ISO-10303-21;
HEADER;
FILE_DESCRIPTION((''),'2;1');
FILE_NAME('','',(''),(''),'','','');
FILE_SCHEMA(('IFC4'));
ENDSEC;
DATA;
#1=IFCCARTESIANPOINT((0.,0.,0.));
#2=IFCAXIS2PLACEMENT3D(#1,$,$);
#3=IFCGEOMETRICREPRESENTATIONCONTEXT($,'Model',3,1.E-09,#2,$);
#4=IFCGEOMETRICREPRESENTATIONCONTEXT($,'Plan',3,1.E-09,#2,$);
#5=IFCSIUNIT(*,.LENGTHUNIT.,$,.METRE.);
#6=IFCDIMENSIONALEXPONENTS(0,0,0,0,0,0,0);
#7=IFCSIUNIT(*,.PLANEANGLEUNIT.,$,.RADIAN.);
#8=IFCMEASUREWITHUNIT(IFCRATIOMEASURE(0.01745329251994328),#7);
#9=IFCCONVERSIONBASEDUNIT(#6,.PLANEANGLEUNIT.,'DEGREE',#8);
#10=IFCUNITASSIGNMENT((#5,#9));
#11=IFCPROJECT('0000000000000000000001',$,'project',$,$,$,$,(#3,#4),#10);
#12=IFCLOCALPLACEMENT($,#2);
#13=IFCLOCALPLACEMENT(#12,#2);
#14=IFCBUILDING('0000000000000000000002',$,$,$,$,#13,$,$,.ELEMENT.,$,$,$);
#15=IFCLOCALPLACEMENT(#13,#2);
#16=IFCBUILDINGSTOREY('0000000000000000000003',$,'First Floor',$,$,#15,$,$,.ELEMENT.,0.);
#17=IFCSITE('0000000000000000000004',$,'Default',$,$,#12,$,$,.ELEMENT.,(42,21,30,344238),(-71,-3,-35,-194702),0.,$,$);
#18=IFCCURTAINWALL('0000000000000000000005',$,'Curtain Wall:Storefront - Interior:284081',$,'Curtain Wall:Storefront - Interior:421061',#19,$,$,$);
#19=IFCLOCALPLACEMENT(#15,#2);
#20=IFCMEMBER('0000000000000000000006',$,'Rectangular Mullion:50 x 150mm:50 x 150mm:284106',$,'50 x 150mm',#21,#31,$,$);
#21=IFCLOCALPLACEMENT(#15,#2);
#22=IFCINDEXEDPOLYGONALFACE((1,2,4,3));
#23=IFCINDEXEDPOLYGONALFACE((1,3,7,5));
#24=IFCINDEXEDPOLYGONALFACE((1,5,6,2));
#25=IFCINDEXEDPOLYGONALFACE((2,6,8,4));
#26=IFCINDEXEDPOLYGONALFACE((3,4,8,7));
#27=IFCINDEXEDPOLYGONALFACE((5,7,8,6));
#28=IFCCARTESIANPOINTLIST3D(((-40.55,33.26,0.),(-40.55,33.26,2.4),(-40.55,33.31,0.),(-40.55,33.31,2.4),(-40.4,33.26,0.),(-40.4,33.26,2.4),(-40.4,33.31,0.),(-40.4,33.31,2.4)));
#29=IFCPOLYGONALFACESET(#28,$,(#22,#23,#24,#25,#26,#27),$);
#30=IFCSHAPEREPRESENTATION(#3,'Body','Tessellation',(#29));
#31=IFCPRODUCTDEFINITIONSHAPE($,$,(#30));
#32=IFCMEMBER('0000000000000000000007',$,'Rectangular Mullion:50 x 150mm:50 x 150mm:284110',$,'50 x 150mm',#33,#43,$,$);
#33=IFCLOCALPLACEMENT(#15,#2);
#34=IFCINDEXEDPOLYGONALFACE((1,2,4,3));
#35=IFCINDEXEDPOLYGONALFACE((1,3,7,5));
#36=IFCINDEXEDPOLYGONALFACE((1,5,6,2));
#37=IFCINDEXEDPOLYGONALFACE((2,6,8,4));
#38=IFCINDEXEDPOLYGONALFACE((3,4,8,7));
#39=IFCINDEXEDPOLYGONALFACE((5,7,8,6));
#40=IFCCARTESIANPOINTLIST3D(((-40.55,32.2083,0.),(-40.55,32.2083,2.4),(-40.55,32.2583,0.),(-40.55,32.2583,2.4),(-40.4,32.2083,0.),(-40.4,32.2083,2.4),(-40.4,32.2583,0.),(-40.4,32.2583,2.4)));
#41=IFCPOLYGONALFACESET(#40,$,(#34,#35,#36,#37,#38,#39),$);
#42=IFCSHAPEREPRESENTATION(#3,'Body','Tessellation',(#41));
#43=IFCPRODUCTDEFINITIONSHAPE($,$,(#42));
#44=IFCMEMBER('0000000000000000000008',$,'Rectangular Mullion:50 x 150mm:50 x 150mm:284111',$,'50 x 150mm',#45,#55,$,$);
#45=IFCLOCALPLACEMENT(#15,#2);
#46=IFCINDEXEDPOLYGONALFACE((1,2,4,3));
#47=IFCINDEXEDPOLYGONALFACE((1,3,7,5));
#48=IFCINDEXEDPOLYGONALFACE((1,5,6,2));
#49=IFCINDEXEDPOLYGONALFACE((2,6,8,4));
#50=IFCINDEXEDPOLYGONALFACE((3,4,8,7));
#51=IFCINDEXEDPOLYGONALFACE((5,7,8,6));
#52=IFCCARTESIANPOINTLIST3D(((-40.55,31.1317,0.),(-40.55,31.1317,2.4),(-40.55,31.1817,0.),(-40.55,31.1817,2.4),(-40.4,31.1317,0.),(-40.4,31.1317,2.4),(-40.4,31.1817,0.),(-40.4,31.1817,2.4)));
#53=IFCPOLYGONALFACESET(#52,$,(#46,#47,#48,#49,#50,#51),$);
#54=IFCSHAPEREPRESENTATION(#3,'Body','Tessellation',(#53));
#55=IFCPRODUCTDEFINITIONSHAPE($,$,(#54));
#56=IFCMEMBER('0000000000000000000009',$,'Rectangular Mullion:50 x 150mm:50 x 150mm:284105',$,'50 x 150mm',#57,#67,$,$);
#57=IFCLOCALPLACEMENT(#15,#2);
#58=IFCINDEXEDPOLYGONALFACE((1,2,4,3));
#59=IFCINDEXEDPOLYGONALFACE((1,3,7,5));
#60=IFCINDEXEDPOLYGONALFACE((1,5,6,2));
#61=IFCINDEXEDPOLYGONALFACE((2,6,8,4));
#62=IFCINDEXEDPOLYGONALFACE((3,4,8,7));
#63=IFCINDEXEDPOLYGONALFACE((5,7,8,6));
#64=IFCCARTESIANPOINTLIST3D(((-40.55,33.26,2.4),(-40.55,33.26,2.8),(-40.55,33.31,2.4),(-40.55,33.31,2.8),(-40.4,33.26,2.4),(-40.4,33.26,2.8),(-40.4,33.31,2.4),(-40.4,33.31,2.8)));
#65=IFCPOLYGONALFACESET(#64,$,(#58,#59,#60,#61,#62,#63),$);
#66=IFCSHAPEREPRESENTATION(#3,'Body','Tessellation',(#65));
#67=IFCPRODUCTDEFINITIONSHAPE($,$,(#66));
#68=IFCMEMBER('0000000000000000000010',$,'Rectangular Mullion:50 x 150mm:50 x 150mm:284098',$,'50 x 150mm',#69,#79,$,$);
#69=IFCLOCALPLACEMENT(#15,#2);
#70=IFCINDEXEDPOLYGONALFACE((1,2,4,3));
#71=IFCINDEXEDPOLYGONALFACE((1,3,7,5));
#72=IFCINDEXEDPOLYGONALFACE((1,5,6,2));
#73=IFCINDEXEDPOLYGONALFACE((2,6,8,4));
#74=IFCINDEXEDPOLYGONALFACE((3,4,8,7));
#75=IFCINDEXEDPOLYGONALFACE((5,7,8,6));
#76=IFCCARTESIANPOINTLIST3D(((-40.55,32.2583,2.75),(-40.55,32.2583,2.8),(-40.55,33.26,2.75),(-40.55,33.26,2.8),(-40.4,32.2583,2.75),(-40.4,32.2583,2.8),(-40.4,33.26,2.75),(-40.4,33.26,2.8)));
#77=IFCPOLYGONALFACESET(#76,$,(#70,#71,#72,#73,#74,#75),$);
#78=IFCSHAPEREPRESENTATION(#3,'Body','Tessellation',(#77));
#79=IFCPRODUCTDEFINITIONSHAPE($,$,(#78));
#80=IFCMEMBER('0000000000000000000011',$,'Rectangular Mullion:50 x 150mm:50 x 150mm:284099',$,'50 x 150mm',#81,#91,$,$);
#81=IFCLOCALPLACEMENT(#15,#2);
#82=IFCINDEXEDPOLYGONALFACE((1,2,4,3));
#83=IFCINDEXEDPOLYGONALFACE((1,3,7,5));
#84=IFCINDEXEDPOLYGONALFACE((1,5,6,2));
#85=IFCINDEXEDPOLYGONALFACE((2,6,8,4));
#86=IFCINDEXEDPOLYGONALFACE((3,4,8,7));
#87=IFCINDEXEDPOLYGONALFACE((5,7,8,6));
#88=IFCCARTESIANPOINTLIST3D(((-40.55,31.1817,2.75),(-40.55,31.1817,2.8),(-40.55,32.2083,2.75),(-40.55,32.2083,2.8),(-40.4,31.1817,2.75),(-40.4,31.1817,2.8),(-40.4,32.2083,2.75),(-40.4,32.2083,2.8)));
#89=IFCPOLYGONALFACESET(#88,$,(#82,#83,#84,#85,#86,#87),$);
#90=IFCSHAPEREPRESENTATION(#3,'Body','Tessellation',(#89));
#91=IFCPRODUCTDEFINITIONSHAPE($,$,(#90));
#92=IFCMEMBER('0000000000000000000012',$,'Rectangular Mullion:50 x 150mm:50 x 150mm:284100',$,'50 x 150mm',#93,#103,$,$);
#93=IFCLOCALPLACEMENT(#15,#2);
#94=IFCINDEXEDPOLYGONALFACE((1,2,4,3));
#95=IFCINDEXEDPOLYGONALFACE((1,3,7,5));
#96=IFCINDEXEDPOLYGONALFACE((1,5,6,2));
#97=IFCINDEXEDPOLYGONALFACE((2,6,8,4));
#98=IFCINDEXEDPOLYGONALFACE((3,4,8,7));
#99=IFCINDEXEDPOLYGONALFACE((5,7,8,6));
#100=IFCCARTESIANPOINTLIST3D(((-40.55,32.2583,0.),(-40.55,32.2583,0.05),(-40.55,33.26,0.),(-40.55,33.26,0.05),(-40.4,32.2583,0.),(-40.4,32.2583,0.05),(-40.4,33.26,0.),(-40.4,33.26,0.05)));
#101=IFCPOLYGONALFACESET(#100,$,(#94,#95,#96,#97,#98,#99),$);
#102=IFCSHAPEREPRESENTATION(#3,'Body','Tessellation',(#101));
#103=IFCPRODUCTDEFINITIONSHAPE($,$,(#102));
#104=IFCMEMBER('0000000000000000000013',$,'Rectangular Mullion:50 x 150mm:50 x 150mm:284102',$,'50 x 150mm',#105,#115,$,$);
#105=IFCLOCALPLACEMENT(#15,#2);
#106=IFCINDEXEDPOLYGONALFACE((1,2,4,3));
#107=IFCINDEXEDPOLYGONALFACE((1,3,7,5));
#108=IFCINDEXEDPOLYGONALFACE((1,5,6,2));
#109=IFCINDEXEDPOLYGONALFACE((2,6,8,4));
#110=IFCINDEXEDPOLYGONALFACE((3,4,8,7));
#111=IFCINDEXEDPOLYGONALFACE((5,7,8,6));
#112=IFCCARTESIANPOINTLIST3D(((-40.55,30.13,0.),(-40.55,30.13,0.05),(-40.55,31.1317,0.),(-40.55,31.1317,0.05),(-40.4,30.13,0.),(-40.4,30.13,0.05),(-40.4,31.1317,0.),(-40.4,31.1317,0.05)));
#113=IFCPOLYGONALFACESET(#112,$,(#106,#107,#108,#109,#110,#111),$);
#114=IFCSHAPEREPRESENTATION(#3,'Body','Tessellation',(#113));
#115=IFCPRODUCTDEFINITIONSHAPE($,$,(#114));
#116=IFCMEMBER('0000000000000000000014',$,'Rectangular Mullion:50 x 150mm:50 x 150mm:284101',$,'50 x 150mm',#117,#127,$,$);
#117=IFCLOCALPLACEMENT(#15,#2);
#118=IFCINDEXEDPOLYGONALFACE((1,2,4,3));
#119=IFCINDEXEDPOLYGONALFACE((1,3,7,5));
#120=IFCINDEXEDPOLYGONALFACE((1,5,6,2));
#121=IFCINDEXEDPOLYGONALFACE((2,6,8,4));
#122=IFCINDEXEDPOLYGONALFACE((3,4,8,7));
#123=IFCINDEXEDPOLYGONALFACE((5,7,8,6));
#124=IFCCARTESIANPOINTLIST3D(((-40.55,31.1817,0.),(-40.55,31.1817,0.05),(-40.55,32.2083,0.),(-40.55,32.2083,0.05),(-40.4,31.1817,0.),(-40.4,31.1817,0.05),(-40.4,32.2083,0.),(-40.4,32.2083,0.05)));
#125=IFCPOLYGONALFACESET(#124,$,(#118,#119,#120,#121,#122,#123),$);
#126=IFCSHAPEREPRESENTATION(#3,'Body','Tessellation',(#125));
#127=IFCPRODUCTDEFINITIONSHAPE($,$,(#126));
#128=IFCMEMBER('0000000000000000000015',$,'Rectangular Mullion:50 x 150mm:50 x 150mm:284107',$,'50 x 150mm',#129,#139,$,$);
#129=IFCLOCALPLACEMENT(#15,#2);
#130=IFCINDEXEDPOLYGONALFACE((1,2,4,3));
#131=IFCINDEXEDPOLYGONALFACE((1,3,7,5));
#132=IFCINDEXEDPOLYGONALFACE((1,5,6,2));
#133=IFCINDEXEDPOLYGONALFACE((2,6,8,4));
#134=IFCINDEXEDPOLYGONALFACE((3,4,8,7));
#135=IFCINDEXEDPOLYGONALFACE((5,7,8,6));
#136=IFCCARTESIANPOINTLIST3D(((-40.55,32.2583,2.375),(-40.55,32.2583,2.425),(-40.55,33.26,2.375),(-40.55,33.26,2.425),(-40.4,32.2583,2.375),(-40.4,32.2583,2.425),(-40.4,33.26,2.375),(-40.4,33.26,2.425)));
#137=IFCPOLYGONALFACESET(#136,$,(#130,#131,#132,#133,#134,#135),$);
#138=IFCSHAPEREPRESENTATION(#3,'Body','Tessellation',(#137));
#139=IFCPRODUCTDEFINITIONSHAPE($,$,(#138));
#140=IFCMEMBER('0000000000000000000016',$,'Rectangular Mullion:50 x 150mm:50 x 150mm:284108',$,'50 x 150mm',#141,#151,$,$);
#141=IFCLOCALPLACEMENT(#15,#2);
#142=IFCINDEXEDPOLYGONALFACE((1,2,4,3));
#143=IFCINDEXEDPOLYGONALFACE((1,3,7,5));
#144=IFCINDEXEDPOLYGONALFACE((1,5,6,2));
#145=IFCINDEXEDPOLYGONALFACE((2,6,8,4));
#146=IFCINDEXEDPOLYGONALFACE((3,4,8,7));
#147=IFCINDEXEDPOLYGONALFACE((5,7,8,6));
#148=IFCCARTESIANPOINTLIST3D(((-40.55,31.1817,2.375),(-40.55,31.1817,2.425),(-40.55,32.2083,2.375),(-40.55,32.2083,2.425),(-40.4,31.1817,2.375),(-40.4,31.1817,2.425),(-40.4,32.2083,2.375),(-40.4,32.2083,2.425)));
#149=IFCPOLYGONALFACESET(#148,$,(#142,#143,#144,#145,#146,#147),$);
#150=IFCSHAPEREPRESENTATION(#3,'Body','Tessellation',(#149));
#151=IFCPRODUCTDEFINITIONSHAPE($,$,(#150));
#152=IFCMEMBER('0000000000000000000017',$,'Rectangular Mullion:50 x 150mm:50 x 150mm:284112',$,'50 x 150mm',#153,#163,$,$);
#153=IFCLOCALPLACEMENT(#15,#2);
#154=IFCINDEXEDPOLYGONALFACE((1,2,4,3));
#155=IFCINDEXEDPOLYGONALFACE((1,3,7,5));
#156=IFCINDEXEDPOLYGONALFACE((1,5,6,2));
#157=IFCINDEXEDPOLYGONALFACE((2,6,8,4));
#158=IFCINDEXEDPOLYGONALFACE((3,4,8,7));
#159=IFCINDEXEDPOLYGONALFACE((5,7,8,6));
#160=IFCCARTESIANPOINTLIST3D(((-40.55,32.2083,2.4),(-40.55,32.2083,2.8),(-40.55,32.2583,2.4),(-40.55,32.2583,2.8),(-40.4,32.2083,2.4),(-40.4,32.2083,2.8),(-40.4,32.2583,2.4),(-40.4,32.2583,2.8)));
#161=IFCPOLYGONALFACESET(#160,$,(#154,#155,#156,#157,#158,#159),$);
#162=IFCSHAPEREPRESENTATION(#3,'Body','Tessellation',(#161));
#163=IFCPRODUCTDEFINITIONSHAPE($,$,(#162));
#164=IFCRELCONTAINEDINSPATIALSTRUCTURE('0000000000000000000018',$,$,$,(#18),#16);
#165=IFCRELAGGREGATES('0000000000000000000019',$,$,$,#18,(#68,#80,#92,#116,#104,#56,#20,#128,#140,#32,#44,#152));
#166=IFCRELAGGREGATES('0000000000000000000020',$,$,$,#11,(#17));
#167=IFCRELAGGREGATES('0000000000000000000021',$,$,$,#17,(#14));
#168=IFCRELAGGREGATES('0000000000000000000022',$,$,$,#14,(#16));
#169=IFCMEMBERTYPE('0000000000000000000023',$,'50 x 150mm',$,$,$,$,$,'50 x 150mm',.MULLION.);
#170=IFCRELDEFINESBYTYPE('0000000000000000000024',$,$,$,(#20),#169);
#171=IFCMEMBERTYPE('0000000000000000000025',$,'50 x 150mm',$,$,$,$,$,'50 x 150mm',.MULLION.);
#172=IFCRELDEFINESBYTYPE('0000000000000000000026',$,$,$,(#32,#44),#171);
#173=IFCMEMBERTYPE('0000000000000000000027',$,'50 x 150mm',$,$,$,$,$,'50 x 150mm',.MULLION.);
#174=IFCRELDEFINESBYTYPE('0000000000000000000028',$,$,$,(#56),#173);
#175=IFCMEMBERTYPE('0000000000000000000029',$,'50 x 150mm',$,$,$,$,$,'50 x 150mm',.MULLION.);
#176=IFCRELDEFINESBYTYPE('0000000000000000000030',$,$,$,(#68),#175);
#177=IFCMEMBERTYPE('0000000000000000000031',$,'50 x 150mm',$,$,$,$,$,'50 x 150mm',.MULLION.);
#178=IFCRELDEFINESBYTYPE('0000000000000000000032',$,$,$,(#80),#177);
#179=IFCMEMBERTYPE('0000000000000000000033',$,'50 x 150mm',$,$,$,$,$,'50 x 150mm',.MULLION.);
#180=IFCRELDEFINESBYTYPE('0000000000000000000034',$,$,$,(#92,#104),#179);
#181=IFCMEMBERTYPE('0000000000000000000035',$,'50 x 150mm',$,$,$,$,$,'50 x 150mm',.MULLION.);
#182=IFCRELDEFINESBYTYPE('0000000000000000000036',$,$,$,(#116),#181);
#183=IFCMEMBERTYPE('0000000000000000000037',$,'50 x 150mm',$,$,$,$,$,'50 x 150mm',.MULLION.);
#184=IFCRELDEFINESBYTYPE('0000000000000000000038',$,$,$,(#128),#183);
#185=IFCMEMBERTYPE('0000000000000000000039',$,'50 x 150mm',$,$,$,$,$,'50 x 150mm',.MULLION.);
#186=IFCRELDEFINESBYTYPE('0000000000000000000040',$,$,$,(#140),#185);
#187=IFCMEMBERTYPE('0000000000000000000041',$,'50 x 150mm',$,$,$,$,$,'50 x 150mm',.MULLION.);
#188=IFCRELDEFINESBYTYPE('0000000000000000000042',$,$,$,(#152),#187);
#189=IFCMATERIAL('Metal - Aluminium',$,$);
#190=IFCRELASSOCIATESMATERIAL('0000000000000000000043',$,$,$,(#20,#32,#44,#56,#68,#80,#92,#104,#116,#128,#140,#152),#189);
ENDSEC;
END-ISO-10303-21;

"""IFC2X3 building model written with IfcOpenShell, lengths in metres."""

from ifc_helpers import new_model, entity, si_unit, converted_unit, frame, origin, origin_2d_with_axis, place, context, project, spatial, rectangle, extrude, source, transform, mapped, material, type_object, type_shapes, element, aggregate, save


model = new_model("IFC2X3")

# Units and contexts
model_context = context("Model", 3, precision=1e-09, world=origin())
plan_context = context("Plan", 3, precision=1e-09, world=origin())
ifc_project = project(units=[si_unit("LENGTHUNIT", "METRE"), converted_unit("PLANEANGLEUNIT", "DEGREE", entity("IfcRatioMeasure", 0.01745329251994328), si_unit("PLANEANGLEUNIT", "RADIAN"), dimensions=[0, 0, 0, 0, 0, 0, 0])], contexts=[model_context, plan_context])

# Site, building, storey
site_placement = place(None, origin())
site = spatial("IfcSite", under=ifc_project, at=site_placement, Name="Default", CompositionType="ELEMENT", RefLatitude=(42, 21, 30, 344238), RefLongitude=(-71, -3, -35, -194702), RefElevation=0.0)
building_placement = place(site_placement, origin())
building = spatial("IfcBuilding", under=site, at=building_placement, CompositionType="ELEMENT")
storey_placement = place(building_placement, origin())
storey = spatial("IfcBuildingStorey", under=building, at=storey_placement, Name="First Floor", CompositionType="ELEMENT", Elevation=0.0)

# Curtain wall, members
curtain_wall_placement = place(storey_placement, origin())
curtain_wall = element("IfcCurtainWall", 1, at=curtain_wall_placement, inside=storey, Name="Curtain Wall:Storefront - Interior:284081", ObjectType="Curtain Wall:Storefront - Interior:421061")
ifc_material_1 = material(Name="Metal - Aluminium")
member_type_1 = type_object("IfcMemberType", Name="50 x 150mm", ElementType="50 x 150mm", PredefinedType="MULLION")
shared_shape_1 = source(origin(), model_context, "Body", "SweptSolid", [
    extrude(rectangle(XDim=0.05, YDim=0.15, at=origin_2d_with_axis()), frame((-0.025, 0.0, -2.4), z_axis=(0.0, 0.0, 1.0), x_axis=(-1.0, 0.0, 0.0)), (0.0, 0.0, 1.0), 2.4),
])
type_shapes(member_type_1, [shared_shape_1])
member_1_placement = place(storey_placement, frame((-40.475, 33.31, 2.4), z_axis=(0.0, 0.0, 1.0), x_axis=(0.0, 1.0, 0.0)))
member_1 = element("IfcMember", 2, at=member_1_placement, type_object=member_type_1, material=ifc_material_1, Name="Rectangular Mullion:50 x 150mm:50 x 150mm:284106", ObjectType="50 x 150mm", context=model_context, shape_type="MappedRepresentation", body=[
    mapped(shared_shape_1, transform((0.0, 0.0, 0.0), scale=1.0)),
])
member_type_2 = type_object("IfcMemberType", Name="50 x 150mm", ElementType="50 x 150mm", PredefinedType="MULLION")
shared_shape_2 = source(origin(), model_context, "Body", "SweptSolid", [
    extrude(rectangle(XDim=0.05, YDim=0.15, at=origin_2d_with_axis()), frame((0.0, 0.0, -2.4), z_axis=(0.0, 0.0, 1.0), x_axis=(-1.0, 0.0, 0.0)), (0.0, 0.0, 1.0), 2.4),
])
type_shapes(member_type_2, [shared_shape_2])
member_2_placement = place(storey_placement, frame((-40.475, 32.2333, 0.0), z_axis=(0.0, 0.0, -1.0), x_axis=(0.0, -1.0, 0.0)))
member_2 = element("IfcMember", 3, at=member_2_placement, type_object=member_type_2, material=ifc_material_1, Name="Rectangular Mullion:50 x 150mm:50 x 150mm:284110", ObjectType="50 x 150mm", context=model_context, shape_type="MappedRepresentation", body=[
    mapped(shared_shape_2, transform((0.0, 0.0, 0.0), scale=1.0)),
])
member_3_placement = place(storey_placement, frame((-40.475, 31.1567, 0.0), z_axis=(0.0, 0.0, -1.0), x_axis=(0.0, -1.0, 0.0)))
member_3 = element("IfcMember", 4, at=member_3_placement, type_object=member_type_2, material=ifc_material_1, Name="Rectangular Mullion:50 x 150mm:50 x 150mm:284111", ObjectType="50 x 150mm", context=model_context, shape_type="MappedRepresentation", body=[
    mapped(shared_shape_2, transform((0.0, 0.0, 0.0), scale=1.0)),
])
member_type_3 = type_object("IfcMemberType", Name="50 x 150mm", ElementType="50 x 150mm", PredefinedType="MULLION")
shared_shape_3 = source(origin(), model_context, "Body", "SweptSolid", [
    extrude(rectangle(XDim=0.05, YDim=0.15, at=origin_2d_with_axis()), frame((-0.025, 0.0, -0.4), z_axis=(0.0, 0.0, 1.0), x_axis=(-1.0, 0.0, 0.0)), (0.0, 0.0, 1.0), 0.4),
])
type_shapes(member_type_3, [shared_shape_3])
member_4_placement = place(storey_placement, frame((-40.475, 33.31, 2.8), z_axis=(0.0, 0.0, 1.0), x_axis=(0.0, 1.0, 0.0)))
member_4 = element("IfcMember", 5, at=member_4_placement, type_object=member_type_3, material=ifc_material_1, Name="Rectangular Mullion:50 x 150mm:50 x 150mm:284105", ObjectType="50 x 150mm", context=model_context, shape_type="MappedRepresentation", body=[
    mapped(shared_shape_3, transform((0.0, 0.0, 0.0), scale=1.0)),
])
member_type_4 = type_object("IfcMemberType", Name="50 x 150mm", ElementType="50 x 150mm", PredefinedType="MULLION")
shared_shape_4 = source(origin(), model_context, "Body", "SweptSolid", [
    extrude(rectangle(XDim=0.05, YDim=0.15, at=origin_2d_with_axis()), frame((-0.025, 0.0, -1.0017), z_axis=(0.0, 0.0, 1.0), x_axis=(-1.0, 0.0, 0.0)), (0.0, 0.0, 1.0), 1.0017),
])
type_shapes(member_type_4, [shared_shape_4])
member_5_placement = place(storey_placement, frame((-40.475, 32.2583, 2.8), z_axis=(0.0, -1.0, 0.0), x_axis=(0.0, 0.0, 1.0)))
member_5 = element("IfcMember", 6, at=member_5_placement, type_object=member_type_4, material=ifc_material_1, Name="Rectangular Mullion:50 x 150mm:50 x 150mm:284098", ObjectType="50 x 150mm", context=model_context, shape_type="MappedRepresentation", body=[
    mapped(shared_shape_4, transform((0.0, 0.0, 0.0), scale=1.0)),
])
member_type_5 = type_object("IfcMemberType", Name="50 x 150mm", ElementType="50 x 150mm", PredefinedType="MULLION")
shared_shape_5 = source(origin(), model_context, "Body", "SweptSolid", [
    extrude(rectangle(XDim=0.05, YDim=0.15, at=origin_2d_with_axis()), frame((-0.025, 0.0, -1.0267), z_axis=(0.0, 0.0, 1.0), x_axis=(-1.0, 0.0, 0.0)), (0.0, 0.0, 1.0), 1.0267),
])
type_shapes(member_type_5, [shared_shape_5])
member_6_placement = place(storey_placement, frame((-40.475, 31.1817, 2.8), z_axis=(0.0, -1.0, 0.0), x_axis=(0.0, 0.0, 1.0)))
member_6 = element("IfcMember", 7, at=member_6_placement, type_object=member_type_5, material=ifc_material_1, Name="Rectangular Mullion:50 x 150mm:50 x 150mm:284099", ObjectType="50 x 150mm", context=model_context, shape_type="MappedRepresentation", body=[
    mapped(shared_shape_5, transform((0.0, 0.0, 0.0), scale=1.0)),
])
member_type_6 = type_object("IfcMemberType", Name="50 x 150mm", ElementType="50 x 150mm", PredefinedType="MULLION")
shared_shape_6 = source(origin(), model_context, "Body", "SweptSolid", [
    extrude(rectangle(XDim=0.05, YDim=0.15, at=origin_2d_with_axis()), frame((-0.025, 0.0, -1.0017), z_axis=(0.0, 0.0, 1.0), x_axis=(-1.0, 0.0, 0.0)), (0.0, 0.0, 1.0), 1.0017),
])
type_shapes(member_type_6, [shared_shape_6])
member_7_placement = place(storey_placement, frame((-40.475, 33.26, 0.0), z_axis=(0.0, 1.0, 0.0), x_axis=(0.0, 0.0, -1.0)))
member_7 = element("IfcMember", 8, at=member_7_placement, type_object=member_type_6, material=ifc_material_1, Name="Rectangular Mullion:50 x 150mm:50 x 150mm:284100", ObjectType="50 x 150mm", context=model_context, shape_type="MappedRepresentation", body=[
    mapped(shared_shape_6, transform((0.0, 0.0, 0.0), scale=1.0)),
])
member_8_placement = place(storey_placement, frame((-40.475, 31.1317, 0.0), z_axis=(0.0, 1.0, 0.0), x_axis=(0.0, 0.0, -1.0)))
member_8 = element("IfcMember", 9, at=member_8_placement, type_object=member_type_6, material=ifc_material_1, Name="Rectangular Mullion:50 x 150mm:50 x 150mm:284102", ObjectType="50 x 150mm", context=model_context, shape_type="MappedRepresentation", body=[
    mapped(shared_shape_6, transform((0.0, 0.0, 0.0), scale=1.0)),
])
member_type_7 = type_object("IfcMemberType", Name="50 x 150mm", ElementType="50 x 150mm", PredefinedType="MULLION")
shared_shape_7 = source(origin(), model_context, "Body", "SweptSolid", [
    extrude(rectangle(XDim=0.05, YDim=0.15, at=origin_2d_with_axis()), frame((-0.025, 0.0, -1.0267), z_axis=(0.0, 0.0, 1.0), x_axis=(-1.0, 0.0, 0.0)), (0.0, 0.0, 1.0), 1.0267),
])
type_shapes(member_type_7, [shared_shape_7])
member_9_placement = place(storey_placement, frame((-40.475, 32.2083, 0.0), z_axis=(0.0, 1.0, 0.0), x_axis=(0.0, 0.0, -1.0)))
member_9 = element("IfcMember", 10, at=member_9_placement, type_object=member_type_7, material=ifc_material_1, Name="Rectangular Mullion:50 x 150mm:50 x 150mm:284101", ObjectType="50 x 150mm", context=model_context, shape_type="MappedRepresentation", body=[
    mapped(shared_shape_7, transform((0.0, 0.0, 0.0), scale=1.0)),
])
member_type_8 = type_object("IfcMemberType", Name="50 x 150mm", ElementType="50 x 150mm", PredefinedType="MULLION")
shared_shape_8 = source(origin(), model_context, "Body", "SweptSolid", [
    extrude(rectangle(XDim=0.05, YDim=0.15, at=origin_2d_with_axis()), frame((0.0, 0.0, -1.0017), z_axis=(0.0, 0.0, 1.0), x_axis=(-1.0, 0.0, 0.0)), (0.0, 0.0, 1.0), 1.0017),
])
type_shapes(member_type_8, [shared_shape_8])
member_10_placement = place(storey_placement, frame((-40.475, 32.2583, 2.4), z_axis=(0.0, -1.0, 0.0), x_axis=(0.0, 0.0, 1.0)))
member_10 = element("IfcMember", 11, at=member_10_placement, type_object=member_type_8, material=ifc_material_1, Name="Rectangular Mullion:50 x 150mm:50 x 150mm:284107", ObjectType="50 x 150mm", context=model_context, shape_type="MappedRepresentation", body=[
    mapped(shared_shape_8, transform((0.0, 0.0, 0.0), scale=1.0)),
])
member_type_9 = type_object("IfcMemberType", Name="50 x 150mm", ElementType="50 x 150mm", PredefinedType="MULLION")
shared_shape_9 = source(origin(), model_context, "Body", "SweptSolid", [
    extrude(rectangle(XDim=0.05, YDim=0.15, at=origin_2d_with_axis()), frame((0.0, 0.0, -1.0267), z_axis=(0.0, 0.0, 1.0), x_axis=(-1.0, 0.0, 0.0)), (0.0, 0.0, 1.0), 1.0267),
])
type_shapes(member_type_9, [shared_shape_9])
member_11_placement = place(storey_placement, frame((-40.475, 31.1817, 2.4), z_axis=(0.0, -1.0, 0.0), x_axis=(0.0, 0.0, 1.0)))
member_11 = element("IfcMember", 12, at=member_11_placement, type_object=member_type_9, material=ifc_material_1, Name="Rectangular Mullion:50 x 150mm:50 x 150mm:284108", ObjectType="50 x 150mm", context=model_context, shape_type="MappedRepresentation", body=[
    mapped(shared_shape_9, transform((0.0, 0.0, 0.0), scale=1.0)),
])
member_type_10 = type_object("IfcMemberType", Name="50 x 150mm", ElementType="50 x 150mm", PredefinedType="MULLION")
shared_shape_10 = source(origin(), model_context, "Body", "SweptSolid", [
    extrude(rectangle(XDim=0.05, YDim=0.15, at=origin_2d_with_axis()), frame((0.0, 0.0, -0.4), z_axis=(0.0, 0.0, 1.0), x_axis=(-1.0, 0.0, 0.0)), (0.0, 0.0, 1.0), 0.4),
])
type_shapes(member_type_10, [shared_shape_10])
member_12_placement = place(storey_placement, frame((-40.475, 32.2333, 2.4), z_axis=(0.0, 0.0, -1.0), x_axis=(0.0, -1.0, 0.0)))
member_12 = element("IfcMember", 13, at=member_12_placement, type_object=member_type_10, material=ifc_material_1, Name="Rectangular Mullion:50 x 150mm:50 x 150mm:284112", ObjectType="50 x 150mm", context=model_context, shape_type="MappedRepresentation", body=[
    mapped(shared_shape_10, transform((0.0, 0.0, 0.0), scale=1.0)),
])
aggregate(curtain_wall, [member_5, member_6, member_7, member_9, member_8, member_4, member_1, member_10, member_11, member_2, member_3, member_12])

save(model, "model.ifc")
